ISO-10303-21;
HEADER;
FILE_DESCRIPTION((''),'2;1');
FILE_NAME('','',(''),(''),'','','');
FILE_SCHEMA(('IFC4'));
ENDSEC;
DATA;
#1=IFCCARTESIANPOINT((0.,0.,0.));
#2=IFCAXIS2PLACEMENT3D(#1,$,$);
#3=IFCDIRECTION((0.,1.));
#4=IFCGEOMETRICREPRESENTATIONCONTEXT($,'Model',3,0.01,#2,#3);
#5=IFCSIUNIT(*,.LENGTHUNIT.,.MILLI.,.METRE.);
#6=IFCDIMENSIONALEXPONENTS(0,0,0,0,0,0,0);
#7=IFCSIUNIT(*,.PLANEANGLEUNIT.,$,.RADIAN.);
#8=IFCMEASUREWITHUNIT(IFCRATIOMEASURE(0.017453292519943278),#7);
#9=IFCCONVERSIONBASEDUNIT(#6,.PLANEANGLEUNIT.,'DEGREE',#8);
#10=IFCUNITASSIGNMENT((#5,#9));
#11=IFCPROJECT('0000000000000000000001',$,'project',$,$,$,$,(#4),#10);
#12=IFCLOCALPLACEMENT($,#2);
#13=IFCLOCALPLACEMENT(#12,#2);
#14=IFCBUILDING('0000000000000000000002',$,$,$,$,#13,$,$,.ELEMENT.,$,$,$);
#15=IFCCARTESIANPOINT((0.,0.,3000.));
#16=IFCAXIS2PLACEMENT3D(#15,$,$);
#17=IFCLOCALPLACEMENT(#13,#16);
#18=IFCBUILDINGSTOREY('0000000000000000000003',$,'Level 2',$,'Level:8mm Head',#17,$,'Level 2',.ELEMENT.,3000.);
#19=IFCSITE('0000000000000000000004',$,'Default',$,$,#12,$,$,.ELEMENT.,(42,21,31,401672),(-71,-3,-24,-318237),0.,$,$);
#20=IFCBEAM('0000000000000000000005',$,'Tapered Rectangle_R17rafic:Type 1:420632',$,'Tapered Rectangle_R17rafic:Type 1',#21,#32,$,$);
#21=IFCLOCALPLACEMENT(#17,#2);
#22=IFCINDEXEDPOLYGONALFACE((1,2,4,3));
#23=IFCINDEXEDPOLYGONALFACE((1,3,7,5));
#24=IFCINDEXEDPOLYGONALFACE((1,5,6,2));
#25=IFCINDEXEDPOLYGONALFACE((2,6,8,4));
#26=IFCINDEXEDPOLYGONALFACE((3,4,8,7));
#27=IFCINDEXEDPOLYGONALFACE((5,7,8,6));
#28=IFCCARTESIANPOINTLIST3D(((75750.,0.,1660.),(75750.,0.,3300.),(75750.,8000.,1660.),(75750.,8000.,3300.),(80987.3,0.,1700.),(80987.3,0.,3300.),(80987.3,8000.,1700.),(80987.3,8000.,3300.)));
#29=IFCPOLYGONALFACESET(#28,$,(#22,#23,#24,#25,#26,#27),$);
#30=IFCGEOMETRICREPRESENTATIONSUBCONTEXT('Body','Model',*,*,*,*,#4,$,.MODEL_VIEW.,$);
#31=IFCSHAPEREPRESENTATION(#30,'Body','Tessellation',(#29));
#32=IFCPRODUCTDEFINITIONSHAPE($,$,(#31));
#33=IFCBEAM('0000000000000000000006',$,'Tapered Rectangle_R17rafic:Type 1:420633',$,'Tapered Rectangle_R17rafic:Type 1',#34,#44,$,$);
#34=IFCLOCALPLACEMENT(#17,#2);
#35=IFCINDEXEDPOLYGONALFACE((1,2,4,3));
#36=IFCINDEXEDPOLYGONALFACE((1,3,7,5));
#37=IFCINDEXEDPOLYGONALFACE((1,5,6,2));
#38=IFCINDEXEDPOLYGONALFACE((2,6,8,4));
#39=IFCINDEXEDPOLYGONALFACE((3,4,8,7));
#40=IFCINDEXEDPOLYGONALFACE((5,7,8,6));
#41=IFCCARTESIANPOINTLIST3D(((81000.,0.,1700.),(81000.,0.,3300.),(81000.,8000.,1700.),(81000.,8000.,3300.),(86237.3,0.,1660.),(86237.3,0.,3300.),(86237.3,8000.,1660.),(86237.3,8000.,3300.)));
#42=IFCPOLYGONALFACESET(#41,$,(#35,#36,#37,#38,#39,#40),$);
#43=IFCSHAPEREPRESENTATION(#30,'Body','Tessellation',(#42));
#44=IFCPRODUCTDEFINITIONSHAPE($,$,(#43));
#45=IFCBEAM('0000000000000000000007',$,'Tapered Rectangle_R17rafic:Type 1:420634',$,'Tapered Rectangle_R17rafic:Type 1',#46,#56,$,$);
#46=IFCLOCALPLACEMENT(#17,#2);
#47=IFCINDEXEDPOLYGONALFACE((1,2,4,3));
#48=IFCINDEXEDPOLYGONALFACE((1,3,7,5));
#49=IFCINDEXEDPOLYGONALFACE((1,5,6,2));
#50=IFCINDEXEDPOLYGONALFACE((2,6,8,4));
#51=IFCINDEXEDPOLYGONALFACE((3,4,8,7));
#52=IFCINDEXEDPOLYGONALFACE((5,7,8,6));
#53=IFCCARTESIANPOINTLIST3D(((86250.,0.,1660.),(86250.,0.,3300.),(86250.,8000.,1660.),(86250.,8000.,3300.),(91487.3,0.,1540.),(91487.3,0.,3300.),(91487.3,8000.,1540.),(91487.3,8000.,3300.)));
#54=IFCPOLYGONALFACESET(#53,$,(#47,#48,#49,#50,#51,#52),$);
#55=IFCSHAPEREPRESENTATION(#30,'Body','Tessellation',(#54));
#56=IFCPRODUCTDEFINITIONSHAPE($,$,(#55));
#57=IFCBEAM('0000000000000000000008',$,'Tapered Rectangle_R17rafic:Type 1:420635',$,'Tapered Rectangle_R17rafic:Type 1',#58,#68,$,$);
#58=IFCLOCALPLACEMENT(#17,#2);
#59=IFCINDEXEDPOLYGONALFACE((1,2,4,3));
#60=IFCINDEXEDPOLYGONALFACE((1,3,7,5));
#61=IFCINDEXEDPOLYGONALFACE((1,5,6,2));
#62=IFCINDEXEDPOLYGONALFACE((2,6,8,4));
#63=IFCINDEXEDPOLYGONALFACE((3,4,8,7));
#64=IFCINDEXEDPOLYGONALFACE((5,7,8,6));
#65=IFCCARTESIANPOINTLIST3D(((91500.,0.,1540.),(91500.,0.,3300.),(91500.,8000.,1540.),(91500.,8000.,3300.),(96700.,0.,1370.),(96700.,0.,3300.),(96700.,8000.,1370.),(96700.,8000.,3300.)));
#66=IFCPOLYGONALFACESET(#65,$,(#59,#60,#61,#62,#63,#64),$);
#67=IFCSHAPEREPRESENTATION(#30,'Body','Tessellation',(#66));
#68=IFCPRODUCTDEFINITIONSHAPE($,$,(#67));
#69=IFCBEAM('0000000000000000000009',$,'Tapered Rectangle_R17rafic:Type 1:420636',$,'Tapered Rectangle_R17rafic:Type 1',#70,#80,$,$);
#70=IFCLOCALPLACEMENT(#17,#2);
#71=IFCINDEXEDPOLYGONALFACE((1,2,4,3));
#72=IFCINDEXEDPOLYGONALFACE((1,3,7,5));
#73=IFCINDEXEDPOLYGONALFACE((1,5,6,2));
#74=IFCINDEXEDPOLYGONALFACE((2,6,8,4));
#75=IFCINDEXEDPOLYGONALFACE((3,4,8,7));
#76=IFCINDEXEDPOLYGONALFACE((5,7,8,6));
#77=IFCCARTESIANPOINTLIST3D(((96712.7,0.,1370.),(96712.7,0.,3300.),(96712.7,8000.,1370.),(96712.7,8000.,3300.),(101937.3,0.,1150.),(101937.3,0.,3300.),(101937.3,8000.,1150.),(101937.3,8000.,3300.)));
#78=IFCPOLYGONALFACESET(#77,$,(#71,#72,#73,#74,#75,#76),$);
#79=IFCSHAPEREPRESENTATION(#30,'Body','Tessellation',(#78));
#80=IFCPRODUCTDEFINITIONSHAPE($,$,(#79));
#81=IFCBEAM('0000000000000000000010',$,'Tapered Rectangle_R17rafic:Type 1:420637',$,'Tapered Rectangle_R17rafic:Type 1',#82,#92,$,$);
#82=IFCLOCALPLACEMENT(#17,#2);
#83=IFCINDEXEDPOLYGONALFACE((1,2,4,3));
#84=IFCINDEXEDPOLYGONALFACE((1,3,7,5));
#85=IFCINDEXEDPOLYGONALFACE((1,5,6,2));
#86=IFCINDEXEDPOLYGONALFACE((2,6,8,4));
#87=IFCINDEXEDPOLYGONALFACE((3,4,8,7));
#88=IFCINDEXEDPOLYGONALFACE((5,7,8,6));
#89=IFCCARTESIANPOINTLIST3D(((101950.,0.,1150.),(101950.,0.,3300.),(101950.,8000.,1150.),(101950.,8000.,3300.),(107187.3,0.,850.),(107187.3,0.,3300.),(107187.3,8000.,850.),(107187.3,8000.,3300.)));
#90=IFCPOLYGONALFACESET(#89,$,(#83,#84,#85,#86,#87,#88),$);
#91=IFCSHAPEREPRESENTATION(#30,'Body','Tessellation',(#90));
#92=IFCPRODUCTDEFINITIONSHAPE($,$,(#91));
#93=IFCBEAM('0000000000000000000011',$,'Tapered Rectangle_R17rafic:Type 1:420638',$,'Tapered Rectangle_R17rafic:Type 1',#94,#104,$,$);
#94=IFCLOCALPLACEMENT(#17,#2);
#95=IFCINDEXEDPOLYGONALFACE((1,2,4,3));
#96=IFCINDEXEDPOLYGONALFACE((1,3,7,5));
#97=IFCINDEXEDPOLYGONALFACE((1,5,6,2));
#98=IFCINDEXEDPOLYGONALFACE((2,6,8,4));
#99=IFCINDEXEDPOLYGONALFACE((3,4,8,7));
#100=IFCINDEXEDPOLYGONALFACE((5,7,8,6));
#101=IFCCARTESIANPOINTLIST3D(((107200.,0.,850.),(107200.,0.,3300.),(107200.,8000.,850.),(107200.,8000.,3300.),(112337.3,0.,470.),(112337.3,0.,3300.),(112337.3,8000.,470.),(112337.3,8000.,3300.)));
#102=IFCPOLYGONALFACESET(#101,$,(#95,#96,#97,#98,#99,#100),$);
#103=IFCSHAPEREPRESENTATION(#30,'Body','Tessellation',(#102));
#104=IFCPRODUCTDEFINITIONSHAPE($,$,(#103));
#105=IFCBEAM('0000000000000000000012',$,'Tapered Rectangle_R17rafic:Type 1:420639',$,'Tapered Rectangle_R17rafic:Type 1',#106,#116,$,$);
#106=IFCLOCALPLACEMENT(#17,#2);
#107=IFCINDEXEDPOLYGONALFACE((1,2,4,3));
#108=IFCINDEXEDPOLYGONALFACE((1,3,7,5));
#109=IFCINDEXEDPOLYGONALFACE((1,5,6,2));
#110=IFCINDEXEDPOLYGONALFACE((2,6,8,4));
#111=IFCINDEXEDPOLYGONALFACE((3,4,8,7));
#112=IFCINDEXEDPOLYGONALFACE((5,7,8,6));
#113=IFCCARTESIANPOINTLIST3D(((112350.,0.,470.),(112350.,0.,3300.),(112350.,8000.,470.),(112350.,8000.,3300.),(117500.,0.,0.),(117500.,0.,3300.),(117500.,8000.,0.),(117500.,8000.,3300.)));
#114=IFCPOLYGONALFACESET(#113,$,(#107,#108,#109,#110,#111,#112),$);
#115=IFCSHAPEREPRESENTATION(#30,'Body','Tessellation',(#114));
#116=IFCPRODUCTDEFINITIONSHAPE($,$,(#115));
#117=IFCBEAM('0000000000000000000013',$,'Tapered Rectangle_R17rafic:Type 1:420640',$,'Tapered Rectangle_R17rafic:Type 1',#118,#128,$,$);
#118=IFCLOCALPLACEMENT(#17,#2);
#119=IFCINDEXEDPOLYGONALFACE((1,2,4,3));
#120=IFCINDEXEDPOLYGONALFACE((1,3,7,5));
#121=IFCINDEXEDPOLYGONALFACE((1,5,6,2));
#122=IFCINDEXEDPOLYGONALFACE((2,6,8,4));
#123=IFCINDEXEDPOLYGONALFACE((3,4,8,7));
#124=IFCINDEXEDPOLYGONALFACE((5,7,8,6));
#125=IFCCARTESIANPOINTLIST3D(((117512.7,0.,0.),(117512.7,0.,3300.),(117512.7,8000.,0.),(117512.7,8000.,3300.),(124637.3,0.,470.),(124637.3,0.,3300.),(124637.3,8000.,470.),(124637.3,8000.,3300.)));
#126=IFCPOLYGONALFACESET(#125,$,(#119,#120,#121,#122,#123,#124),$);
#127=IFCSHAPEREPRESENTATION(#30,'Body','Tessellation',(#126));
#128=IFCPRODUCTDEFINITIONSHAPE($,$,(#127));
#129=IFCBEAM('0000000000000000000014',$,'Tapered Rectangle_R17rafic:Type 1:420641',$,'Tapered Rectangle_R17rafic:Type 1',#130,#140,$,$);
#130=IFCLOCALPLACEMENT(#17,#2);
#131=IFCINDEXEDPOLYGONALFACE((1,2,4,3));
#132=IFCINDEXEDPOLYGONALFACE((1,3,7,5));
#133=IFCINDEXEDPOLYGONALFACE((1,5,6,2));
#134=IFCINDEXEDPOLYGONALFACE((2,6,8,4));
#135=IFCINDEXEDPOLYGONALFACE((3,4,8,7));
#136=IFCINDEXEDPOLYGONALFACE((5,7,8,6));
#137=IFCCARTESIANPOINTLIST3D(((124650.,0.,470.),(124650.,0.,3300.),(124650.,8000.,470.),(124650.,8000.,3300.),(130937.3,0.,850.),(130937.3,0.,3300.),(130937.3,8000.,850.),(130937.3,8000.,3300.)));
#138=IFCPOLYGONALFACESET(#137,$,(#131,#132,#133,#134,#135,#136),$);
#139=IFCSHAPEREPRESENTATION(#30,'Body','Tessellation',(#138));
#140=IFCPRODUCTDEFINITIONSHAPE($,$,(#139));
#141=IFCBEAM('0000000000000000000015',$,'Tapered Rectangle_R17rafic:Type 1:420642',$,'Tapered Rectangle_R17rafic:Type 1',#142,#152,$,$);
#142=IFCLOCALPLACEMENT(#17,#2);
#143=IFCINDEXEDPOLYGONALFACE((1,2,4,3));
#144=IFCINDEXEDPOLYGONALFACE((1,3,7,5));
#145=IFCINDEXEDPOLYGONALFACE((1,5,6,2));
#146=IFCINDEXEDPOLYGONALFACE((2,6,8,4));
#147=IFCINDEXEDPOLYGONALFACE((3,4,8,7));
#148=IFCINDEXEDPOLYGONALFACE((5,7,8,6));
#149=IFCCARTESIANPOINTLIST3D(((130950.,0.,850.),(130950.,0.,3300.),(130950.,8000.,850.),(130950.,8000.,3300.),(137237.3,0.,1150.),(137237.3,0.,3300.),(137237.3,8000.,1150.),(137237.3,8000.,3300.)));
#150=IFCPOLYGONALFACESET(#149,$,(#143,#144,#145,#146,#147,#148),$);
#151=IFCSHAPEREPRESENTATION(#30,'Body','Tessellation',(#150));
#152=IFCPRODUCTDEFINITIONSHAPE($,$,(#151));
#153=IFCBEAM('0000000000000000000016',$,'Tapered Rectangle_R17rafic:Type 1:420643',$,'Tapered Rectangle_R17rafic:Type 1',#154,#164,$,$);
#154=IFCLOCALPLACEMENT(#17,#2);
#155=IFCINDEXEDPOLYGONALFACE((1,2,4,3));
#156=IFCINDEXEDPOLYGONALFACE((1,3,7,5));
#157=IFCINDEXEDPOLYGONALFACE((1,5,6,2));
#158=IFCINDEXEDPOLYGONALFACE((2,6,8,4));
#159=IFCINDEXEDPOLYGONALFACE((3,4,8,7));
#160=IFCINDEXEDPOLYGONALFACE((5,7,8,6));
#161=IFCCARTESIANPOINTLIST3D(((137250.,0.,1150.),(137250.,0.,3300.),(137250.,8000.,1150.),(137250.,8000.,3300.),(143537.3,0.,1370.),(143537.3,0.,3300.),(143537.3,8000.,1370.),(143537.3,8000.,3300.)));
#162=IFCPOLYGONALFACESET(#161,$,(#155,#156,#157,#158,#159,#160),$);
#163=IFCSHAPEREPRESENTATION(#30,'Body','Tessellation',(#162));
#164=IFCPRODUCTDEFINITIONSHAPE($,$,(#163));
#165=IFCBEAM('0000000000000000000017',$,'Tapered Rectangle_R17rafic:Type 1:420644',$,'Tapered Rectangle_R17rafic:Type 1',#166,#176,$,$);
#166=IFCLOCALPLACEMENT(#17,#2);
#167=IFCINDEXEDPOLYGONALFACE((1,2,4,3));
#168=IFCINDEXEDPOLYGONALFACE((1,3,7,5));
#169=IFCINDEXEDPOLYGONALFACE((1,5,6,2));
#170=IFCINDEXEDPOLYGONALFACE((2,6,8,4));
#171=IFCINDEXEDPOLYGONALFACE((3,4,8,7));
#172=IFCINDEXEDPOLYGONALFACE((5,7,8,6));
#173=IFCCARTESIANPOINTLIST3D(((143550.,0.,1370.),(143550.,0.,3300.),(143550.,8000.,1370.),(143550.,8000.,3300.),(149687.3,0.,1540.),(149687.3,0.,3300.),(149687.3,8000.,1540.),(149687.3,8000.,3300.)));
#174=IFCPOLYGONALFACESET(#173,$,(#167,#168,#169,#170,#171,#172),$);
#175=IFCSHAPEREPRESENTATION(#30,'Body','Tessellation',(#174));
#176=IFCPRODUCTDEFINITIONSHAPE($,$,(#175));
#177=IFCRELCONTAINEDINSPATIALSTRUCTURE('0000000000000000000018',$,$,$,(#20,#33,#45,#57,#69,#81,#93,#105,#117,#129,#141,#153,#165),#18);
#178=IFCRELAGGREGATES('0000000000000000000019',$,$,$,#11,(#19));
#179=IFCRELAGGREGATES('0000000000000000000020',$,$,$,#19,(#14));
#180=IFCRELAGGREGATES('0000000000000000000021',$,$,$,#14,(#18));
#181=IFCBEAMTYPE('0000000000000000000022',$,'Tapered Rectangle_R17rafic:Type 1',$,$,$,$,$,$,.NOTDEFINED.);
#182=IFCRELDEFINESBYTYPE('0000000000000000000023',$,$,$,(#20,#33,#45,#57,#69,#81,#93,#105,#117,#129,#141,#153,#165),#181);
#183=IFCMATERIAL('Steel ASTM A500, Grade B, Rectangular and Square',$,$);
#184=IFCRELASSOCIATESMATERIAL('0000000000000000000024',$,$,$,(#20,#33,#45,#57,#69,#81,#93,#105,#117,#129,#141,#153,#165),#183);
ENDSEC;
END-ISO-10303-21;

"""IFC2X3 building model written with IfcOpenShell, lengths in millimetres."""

from ifc_helpers import new_model, entity, si_unit, converted_unit, direction, frame, frame_2d, origin, place, context, subcontext, project, spatial, rectangle, extrude, clip, halfspace, material, type_object, element, save


model = new_model("IFC2X3")

# Units and contexts
model_context = context("Model", 3, precision=0.01, world=origin(), true_north=direction((0.0, 1.0)))
body_context = subcontext(model_context, "Body", "Model", "MODEL_VIEW")
ifc_project = project(units=[si_unit("LENGTHUNIT", "METRE", prefix="MILLI"), converted_unit("PLANEANGLEUNIT", "DEGREE", entity("IfcRatioMeasure", 0.017453292519943278), si_unit("PLANEANGLEUNIT", "RADIAN"), dimensions=[0, 0, 0, 0, 0, 0, 0])], contexts=[model_context])

# Site, building, storey
site_placement = place(None, origin())
site = spatial("IfcSite", under=ifc_project, at=site_placement, Name="Default", CompositionType="ELEMENT", RefLatitude=(42, 21, 31, 401672), RefLongitude=(-71, -3, -24, -318237), RefElevation=0.0)
building_placement = place(site_placement, origin())
building = spatial("IfcBuilding", under=site, at=building_placement, CompositionType="ELEMENT")
storey_placement = place(building_placement, frame((0.0, 0.0, 3000.0)))
storey = spatial("IfcBuildingStorey", under=building, at=storey_placement, Name="Level 2", ObjectType="Level:8mm Head", LongName="Level 2", CompositionType="ELEMENT", Elevation=3000.0)

# Beams
ifc_material = material(Name="Steel ASTM A500, Grade B, Rectangular and Square")
beam_type = type_object("IfcBeamType", Name="Tapered Rectangle_R17rafic:Type 1", PredefinedType="NOTDEFINED")
beam_1_placement = place(storey_placement, frame((75750.0, 4000.0, 3300.0)))
element("IfcBeam", 1, at=beam_1_placement, inside=storey, type_object=beam_type, material=ifc_material, Name="Tapered Rectangle_R17rafic:Type 1:420632", ObjectType="Tapered Rectangle_R17rafic:Type 1", context=body_context, shape_type="SweptSolid", body=[
    clip(extrude(rectangle(XDim=1640.0, YDim=8000.0, at=frame_2d((0.0, 0.0), x_axis=(0.0, 1.0))), frame((0.0, 0.0, -820.0), z_axis=(1.0, 0.0, 0.0), x_axis=(0.0, 1.0, 0.0)), (0.0, 0.0, 1.0), 5237.3), halfspace(frame((0.0, 0.0, -1640.0), z_axis=(0.007637, 0.0, -0.999971), x_axis=(0.0, 1.0, 0.0)), False)),
])
beam_2_placement = place(storey_placement, frame((81000.0, 4000.0, 3300.0)))
element("IfcBeam", 2, at=beam_2_placement, inside=storey, type_object=beam_type, material=ifc_material, Name="Tapered Rectangle_R17rafic:Type 1:420633", ObjectType="Tapered Rectangle_R17rafic:Type 1", context=body_context, shape_type="SweptSolid", body=[
    clip(extrude(rectangle(XDim=1640.0, YDim=8000.0, at=frame_2d((0.0, 0.0), x_axis=(0.0, 1.0))), frame((0.0, 0.0, -820.0), z_axis=(1.0, 0.0, 0.0), x_axis=(0.0, 1.0, 0.0)), (0.0, 0.0, 1.0), 5237.3), halfspace(frame((0.0, 0.0, -1600.0), z_axis=(-0.007637, 0.0, -0.999971), x_axis=(0.0, 1.0, 0.0)), False)),
])
beam_3_placement = place(storey_placement, frame((86250.0, 4000.0, 3300.0)))
element("IfcBeam", 3, at=beam_3_placement, inside=storey, type_object=beam_type, material=ifc_material, Name="Tapered Rectangle_R17rafic:Type 1:420634", ObjectType="Tapered Rectangle_R17rafic:Type 1", context=body_context, shape_type="SweptSolid", body=[
    clip(extrude(rectangle(XDim=1760.0, YDim=8000.0, at=frame_2d((0.0, 0.0), x_axis=(0.0, 1.0))), frame((0.0, 0.0, -880.0), z_axis=(1.0, 0.0, 0.0), x_axis=(0.0, 1.0, 0.0)), (0.0, 0.0, 1.0), 5237.3), halfspace(frame((0.0, 0.0, -1640.0), z_axis=(-0.022907, 0.0, -0.999738), x_axis=(0.0, 1.0, 0.0)), False)),
])
beam_4_placement = place(storey_placement, frame((91500.0, 4000.0, 3300.0)))
element("IfcBeam", 4, at=beam_4_placement, inside=storey, type_object=beam_type, material=ifc_material, Name="Tapered Rectangle_R17rafic:Type 1:420635", ObjectType="Tapered Rectangle_R17rafic:Type 1", context=body_context, shape_type="SweptSolid", body=[
    clip(extrude(rectangle(XDim=1930.0, YDim=8000.0, at=frame_2d((0.0, 0.0), x_axis=(0.0, 1.0))), frame((0.0, 0.0, -965.0), z_axis=(1.0, 0.0, 0.0), x_axis=(0.0, 1.0, 0.0)), (0.0, 0.0, 1.0), 5200.0), halfspace(frame((0.0, 0.0, -1760.0), z_axis=(-0.032675, 0.0, -0.999466), x_axis=(0.0, 1.0, 0.0)), False)),
])
beam_5_placement = place(storey_placement, frame((96700.0, 4000.0, 3300.0)))
element("IfcBeam", 5, at=beam_5_placement, inside=storey, type_object=beam_type, material=ifc_material, Name="Tapered Rectangle_R17rafic:Type 1:420636", ObjectType="Tapered Rectangle_R17rafic:Type 1", context=body_context, shape_type="SweptSolid", body=[
    clip(extrude(rectangle(XDim=2150.0, YDim=8000.0, at=frame_2d((0.0, 0.0), x_axis=(0.0, 1.0))), frame((12.7, 0.0, -1075.0), z_axis=(1.0, 0.0, 0.0), x_axis=(0.0, 1.0, 0.0)), (0.0, 0.0, 1.0), 5224.6), halfspace(frame((12.7, 0.0, -1930.0), z_axis=(-0.042071, 0.0, -0.999115), x_axis=(0.0, 1.0, 0.0)), False)),
])
beam_6_placement = place(storey_placement, frame((101950.0, 4000.0, 3300.0)))
element("IfcBeam", 6, at=beam_6_placement, inside=storey, type_object=beam_type, material=ifc_material, Name="Tapered Rectangle_R17rafic:Type 1:420637", ObjectType="Tapered Rectangle_R17rafic:Type 1", context=body_context, shape_type="SweptSolid", body=[
    clip(extrude(rectangle(XDim=2450.0, YDim=8000.0, at=frame_2d((0.0, 0.0), x_axis=(0.0, 1.0))), frame((0.0, 0.0, -1225.0), z_axis=(1.0, 0.0, 0.0), x_axis=(0.0, 1.0, 0.0)), (0.0, 0.0, 1.0), 5237.3), halfspace(frame((0.0, 0.0, -2150.0), z_axis=(-0.057188, 0.0, -0.998363), x_axis=(0.0, 1.0, 0.0)), False)),
])
beam_7_placement = place(storey_placement, frame((107200.0, 4000.0, 3300.0)))
element("IfcBeam", 7, at=beam_7_placement, inside=storey, type_object=beam_type, material=ifc_material, Name="Tapered Rectangle_R17rafic:Type 1:420638", ObjectType="Tapered Rectangle_R17rafic:Type 1", context=body_context, shape_type="SweptSolid", body=[
    clip(extrude(rectangle(XDim=2830.0, YDim=8000.0, at=frame_2d((0.0, 0.0), x_axis=(0.0, 1.0))), frame((0.0, 0.0, -1415.0), z_axis=(1.0, 0.0, 0.0), x_axis=(0.0, 1.0, 0.0)), (0.0, 0.0, 1.0), 5137.3), halfspace(frame((0.0, 0.0, -2450.0), z_axis=(-0.073767, 0.0, -0.997275), x_axis=(0.0, 1.0, 0.0)), False)),
])
beam_8_placement = place(storey_placement, frame((112350.0, 4000.0, 3300.0)))
element("IfcBeam", 8, at=beam_8_placement, inside=storey, type_object=beam_type, material=ifc_material, Name="Tapered Rectangle_R17rafic:Type 1:420639", ObjectType="Tapered Rectangle_R17rafic:Type 1", context=body_context, shape_type="SweptSolid", body=[
    clip(extrude(rectangle(XDim=3300.0, YDim=8000.0, at=frame_2d((0.0, 0.0), x_axis=(0.0, 1.0))), frame((0.0, 0.0, -1650.0), z_axis=(1.0, 0.0, 0.0), x_axis=(0.0, 1.0, 0.0)), (0.0, 0.0, 1.0), 5150.0), halfspace(frame((0.0, 0.0, -2830.0), z_axis=(-0.090884, 0.0, -0.995861), x_axis=(0.0, 1.0, 0.0)), False)),
])
beam_9_placement = place(storey_placement, frame((117500.0, 4000.0, 3300.0)))
element("IfcBeam", 9, at=beam_9_placement, inside=storey, type_object=beam_type, material=ifc_material, Name="Tapered Rectangle_R17rafic:Type 1:420640", ObjectType="Tapered Rectangle_R17rafic:Type 1", context=body_context, shape_type="SweptSolid", body=[
    clip(extrude(rectangle(XDim=3300.0, YDim=8000.0, at=frame_2d((0.0, 0.0), x_axis=(0.0, 1.0))), frame((12.7, 0.0, -1650.0), z_axis=(1.0, 0.0, 0.0), x_axis=(0.0, 1.0, 0.0)), (0.0, 0.0, 1.0), 7124.6), halfspace(frame((12.7, 0.0, -3300.0), z_axis=(0.065826, 0.0, -0.997831), x_axis=(0.0, 1.0, 0.0)), False)),
])
beam_10_placement = place(storey_placement, frame((124650.0, 4000.0, 3300.0)))
element("IfcBeam", 10, at=beam_10_placement, inside=storey, type_object=beam_type, material=ifc_material, Name="Tapered Rectangle_R17rafic:Type 1:420641", ObjectType="Tapered Rectangle_R17rafic:Type 1", context=body_context, shape_type="SweptSolid", body=[
    clip(extrude(rectangle(XDim=2830.0, YDim=8000.0, at=frame_2d((0.0, 0.0), x_axis=(0.0, 1.0))), frame((0.0, 0.0, -1415.0), z_axis=(1.0, 0.0, 0.0), x_axis=(0.0, 1.0, 0.0)), (0.0, 0.0, 1.0), 6287.3), halfspace(frame((0.0, 0.0, -2830.0), z_axis=(0.060329, 0.0, -0.998179), x_axis=(0.0, 1.0, 0.0)), False)),
])
beam_11_placement = place(storey_placement, frame((130950.0, 4000.0, 3300.0)))
element("IfcBeam", 11, at=beam_11_placement, inside=storey, type_object=beam_type, material=ifc_material, Name="Tapered Rectangle_R17rafic:Type 1:420642", ObjectType="Tapered Rectangle_R17rafic:Type 1", context=body_context, shape_type="SweptSolid", body=[
    clip(extrude(rectangle(XDim=2450.0, YDim=8000.0, at=frame_2d((0.0, 0.0), x_axis=(0.0, 1.0))), frame((0.0, 0.0, -1225.0), z_axis=(1.0, 0.0, 0.0), x_axis=(0.0, 1.0, 0.0)), (0.0, 0.0, 1.0), 6287.3), halfspace(frame((0.0, 0.0, -2450.0), z_axis=(0.047661, 0.0, -0.998864), x_axis=(0.0, 1.0, 0.0)), False)),
])
beam_12_placement = place(storey_placement, frame((137250.0, 4000.0, 3300.0)))
element("IfcBeam", 12, at=beam_12_placement, inside=storey, type_object=beam_type, material=ifc_material, Name="Tapered Rectangle_R17rafic:Type 1:420643", ObjectType="Tapered Rectangle_R17rafic:Type 1", context=body_context, shape_type="SweptSolid", body=[
    clip(extrude(rectangle(XDim=2150.0, YDim=8000.0, at=frame_2d((0.0, 0.0), x_axis=(0.0, 1.0))), frame((0.0, 0.0, -1075.0), z_axis=(1.0, 0.0, 0.0), x_axis=(0.0, 1.0, 0.0)), (0.0, 0.0, 1.0), 6287.3), halfspace(frame((0.0, 0.0, -2150.0), z_axis=(0.03497, 0.0, -0.999388), x_axis=(0.0, 1.0, 0.0)), False)),
])
beam_13_placement = place(storey_placement, frame((143550.0, 4000.0, 3300.0)))
element("IfcBeam", 13, at=beam_13_placement, inside=storey, type_object=beam_type, material=ifc_material, Name="Tapered Rectangle_R17rafic:Type 1:420644", ObjectType="Tapered Rectangle_R17rafic:Type 1", context=body_context, shape_type="SweptSolid", body=[
    clip(extrude(rectangle(XDim=1930.0, YDim=8000.0, at=frame_2d((0.0, 0.0), x_axis=(0.0, 1.0))), frame((0.0, 0.0, -965.0), z_axis=(1.0, 0.0, 0.0), x_axis=(0.0, 1.0, 0.0)), (0.0, 0.0, 1.0), 6137.3), halfspace(frame((0.0, 0.0, -1930.0), z_axis=(0.027689, 0.0, -0.999617), x_axis=(0.0, 1.0, 0.0)), False)),
])

save(model, "model.ifc")
